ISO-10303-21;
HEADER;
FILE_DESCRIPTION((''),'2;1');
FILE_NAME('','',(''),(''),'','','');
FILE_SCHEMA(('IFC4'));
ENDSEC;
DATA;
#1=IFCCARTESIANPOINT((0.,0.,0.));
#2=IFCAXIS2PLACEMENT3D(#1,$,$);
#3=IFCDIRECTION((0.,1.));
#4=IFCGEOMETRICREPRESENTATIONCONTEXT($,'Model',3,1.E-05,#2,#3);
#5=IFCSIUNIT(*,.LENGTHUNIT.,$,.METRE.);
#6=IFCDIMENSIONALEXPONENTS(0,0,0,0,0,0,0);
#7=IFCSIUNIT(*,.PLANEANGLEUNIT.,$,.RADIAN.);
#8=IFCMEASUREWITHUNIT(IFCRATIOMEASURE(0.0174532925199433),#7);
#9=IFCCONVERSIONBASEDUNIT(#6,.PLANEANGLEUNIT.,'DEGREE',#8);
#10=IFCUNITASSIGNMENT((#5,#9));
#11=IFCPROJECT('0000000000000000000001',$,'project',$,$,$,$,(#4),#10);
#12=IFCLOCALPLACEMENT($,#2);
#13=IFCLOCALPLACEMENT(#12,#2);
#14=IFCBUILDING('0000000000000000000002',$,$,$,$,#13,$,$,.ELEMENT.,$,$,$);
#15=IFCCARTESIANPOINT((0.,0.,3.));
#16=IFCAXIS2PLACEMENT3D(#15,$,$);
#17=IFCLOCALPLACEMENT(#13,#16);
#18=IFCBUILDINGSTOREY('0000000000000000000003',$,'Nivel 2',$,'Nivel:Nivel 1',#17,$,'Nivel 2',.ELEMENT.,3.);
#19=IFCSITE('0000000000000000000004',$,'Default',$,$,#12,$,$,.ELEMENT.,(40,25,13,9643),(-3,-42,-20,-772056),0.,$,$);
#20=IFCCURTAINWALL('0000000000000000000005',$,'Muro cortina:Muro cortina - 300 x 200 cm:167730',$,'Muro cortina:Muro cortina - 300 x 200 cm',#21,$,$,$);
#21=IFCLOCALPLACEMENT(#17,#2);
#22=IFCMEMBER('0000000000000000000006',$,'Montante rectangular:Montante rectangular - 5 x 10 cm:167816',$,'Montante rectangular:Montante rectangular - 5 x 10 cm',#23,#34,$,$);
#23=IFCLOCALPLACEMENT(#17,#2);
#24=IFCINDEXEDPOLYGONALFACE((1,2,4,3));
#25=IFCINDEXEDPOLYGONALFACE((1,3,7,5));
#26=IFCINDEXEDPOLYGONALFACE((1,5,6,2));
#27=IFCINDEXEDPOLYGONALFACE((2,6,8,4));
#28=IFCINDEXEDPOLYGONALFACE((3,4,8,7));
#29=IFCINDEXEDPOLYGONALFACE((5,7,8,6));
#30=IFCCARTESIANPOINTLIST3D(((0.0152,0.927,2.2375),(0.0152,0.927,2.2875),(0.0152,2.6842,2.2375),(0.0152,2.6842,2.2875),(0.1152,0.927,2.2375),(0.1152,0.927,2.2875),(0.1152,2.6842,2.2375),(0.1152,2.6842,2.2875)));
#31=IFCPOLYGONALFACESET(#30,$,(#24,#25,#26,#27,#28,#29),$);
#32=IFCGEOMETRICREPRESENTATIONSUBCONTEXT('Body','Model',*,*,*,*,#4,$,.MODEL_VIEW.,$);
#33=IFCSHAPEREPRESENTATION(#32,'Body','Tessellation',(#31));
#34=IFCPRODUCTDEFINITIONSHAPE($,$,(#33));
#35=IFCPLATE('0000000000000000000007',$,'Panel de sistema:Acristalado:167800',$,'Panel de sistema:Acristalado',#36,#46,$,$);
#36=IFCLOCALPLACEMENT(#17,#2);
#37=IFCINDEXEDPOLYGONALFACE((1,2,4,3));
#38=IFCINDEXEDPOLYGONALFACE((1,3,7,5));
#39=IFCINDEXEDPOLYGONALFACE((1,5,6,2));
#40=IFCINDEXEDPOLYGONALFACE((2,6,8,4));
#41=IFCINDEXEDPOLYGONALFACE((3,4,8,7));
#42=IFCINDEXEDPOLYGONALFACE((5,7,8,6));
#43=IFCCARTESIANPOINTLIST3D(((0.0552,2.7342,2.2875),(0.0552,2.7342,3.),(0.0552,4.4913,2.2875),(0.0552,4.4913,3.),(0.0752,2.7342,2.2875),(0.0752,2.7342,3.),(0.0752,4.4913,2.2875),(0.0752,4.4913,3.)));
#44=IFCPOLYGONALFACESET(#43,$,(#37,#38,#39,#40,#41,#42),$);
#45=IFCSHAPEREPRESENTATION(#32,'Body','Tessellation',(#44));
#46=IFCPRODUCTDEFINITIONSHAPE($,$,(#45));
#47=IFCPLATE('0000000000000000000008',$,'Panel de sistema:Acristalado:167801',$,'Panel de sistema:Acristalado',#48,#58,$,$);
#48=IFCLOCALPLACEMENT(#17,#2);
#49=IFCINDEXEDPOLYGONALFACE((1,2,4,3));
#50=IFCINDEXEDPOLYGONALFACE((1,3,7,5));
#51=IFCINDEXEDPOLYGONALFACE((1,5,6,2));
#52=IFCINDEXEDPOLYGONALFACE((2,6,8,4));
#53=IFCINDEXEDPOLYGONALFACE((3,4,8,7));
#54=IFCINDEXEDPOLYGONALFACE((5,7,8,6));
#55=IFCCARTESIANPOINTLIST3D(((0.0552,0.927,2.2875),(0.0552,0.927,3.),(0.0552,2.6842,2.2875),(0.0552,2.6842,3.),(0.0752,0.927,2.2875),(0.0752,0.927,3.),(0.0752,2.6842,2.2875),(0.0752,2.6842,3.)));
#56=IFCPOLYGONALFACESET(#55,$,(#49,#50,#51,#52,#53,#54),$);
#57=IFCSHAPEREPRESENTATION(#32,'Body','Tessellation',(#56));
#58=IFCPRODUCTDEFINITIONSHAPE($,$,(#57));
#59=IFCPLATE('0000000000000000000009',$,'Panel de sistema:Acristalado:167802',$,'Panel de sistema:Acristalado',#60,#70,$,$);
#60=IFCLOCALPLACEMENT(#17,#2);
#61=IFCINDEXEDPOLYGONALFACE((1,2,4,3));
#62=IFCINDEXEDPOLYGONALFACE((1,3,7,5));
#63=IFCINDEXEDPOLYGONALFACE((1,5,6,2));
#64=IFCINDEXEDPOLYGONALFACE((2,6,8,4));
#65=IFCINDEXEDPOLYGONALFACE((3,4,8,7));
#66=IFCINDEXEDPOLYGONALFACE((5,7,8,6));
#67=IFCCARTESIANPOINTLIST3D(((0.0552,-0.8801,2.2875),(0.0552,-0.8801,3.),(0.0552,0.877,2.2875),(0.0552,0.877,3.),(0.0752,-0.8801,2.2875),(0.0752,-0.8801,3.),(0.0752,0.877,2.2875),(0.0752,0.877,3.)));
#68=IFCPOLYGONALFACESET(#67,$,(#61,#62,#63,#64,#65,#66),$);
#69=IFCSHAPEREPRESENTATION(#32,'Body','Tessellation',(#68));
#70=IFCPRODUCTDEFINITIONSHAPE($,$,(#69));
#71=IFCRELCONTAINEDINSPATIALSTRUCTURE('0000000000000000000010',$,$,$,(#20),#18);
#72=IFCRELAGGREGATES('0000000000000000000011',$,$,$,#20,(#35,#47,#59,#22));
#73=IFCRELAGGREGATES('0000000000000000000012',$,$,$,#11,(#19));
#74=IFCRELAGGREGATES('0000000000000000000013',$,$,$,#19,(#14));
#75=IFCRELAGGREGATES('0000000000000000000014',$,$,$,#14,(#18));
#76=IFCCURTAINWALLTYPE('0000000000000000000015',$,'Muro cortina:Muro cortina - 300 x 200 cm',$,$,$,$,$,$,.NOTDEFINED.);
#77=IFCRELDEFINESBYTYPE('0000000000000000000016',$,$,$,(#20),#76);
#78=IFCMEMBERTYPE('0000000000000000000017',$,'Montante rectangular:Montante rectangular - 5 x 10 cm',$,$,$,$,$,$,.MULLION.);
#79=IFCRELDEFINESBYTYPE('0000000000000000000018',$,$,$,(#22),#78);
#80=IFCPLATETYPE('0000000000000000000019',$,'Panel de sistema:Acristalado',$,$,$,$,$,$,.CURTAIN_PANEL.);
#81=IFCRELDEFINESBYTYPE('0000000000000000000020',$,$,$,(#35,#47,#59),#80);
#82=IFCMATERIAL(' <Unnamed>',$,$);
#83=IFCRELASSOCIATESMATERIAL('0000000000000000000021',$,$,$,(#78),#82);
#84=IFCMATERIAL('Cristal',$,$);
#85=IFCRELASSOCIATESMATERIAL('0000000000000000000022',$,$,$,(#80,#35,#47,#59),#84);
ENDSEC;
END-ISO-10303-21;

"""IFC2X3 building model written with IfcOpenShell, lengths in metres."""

from ifc_helpers import new_model, entity, si_unit, converted_unit, direction, frame, origin, origin_2d_with_axis, place, context, subcontext, project, spatial, rectangle, extrude, source, transform, mapped, material, type_object, type_shapes, element, aggregate, save


model = new_model("IFC2X3")

# Units and contexts
model_context = context("Model", 3, precision=1e-05, world=origin(), true_north=direction((0.0, 1.0)))
body_context = subcontext(model_context, "Body", "Model", "MODEL_VIEW")
ifc_project = project(units=[si_unit("LENGTHUNIT", "METRE"), converted_unit("PLANEANGLEUNIT", "DEGREE", entity("IfcRatioMeasure", 0.0174532925199433), si_unit("PLANEANGLEUNIT", "RADIAN"), dimensions=[0, 0, 0, 0, 0, 0, 0])], contexts=[model_context])

# Site, building, storey
site_placement = place(None, origin())
site = spatial("IfcSite", under=ifc_project, at=site_placement, Name="Default", CompositionType="ELEMENT", RefLatitude=(40, 25, 13, 9643), RefLongitude=(-3, -42, -20, -772056), RefElevation=0.0)
building_placement = place(site_placement, origin())
building = spatial("IfcBuilding", under=site, at=building_placement, CompositionType="ELEMENT")
storey_placement = place(building_placement, frame((0.0, 0.0, 3.0)))
storey = spatial("IfcBuildingStorey", under=building, at=storey_placement, Name="Nivel 2", ObjectType="Nivel:Nivel 1", LongName="Nivel 2", CompositionType="ELEMENT", Elevation=3.0)

# Curtain wall, member, plates
curtain_wall_type = type_object("IfcCurtainWallType", Name="Muro cortina:Muro cortina - 300 x 200 cm", PredefinedType="NOTDEFINED")
curtain_wall_placement = place(storey_placement, frame((0.0, 0.0, -3.0)))
curtain_wall = element("IfcCurtainWall", 1, at=curtain_wall_placement, inside=storey, type_object=curtain_wall_type, Name="Muro cortina:Muro cortina - 300 x 200 cm:167730", ObjectType="Muro cortina:Muro cortina - 300 x 200 cm")
ifc_material_1 = material(Name=" <Unnamed>")
member_type_1 = type_object("IfcMemberType", Name="Montante rectangular:Montante rectangular - 5 x 10 cm", PredefinedType="MULLION", material=ifc_material_1)
shared_shape_1 = source(origin(), body_context, "Body", "SweptSolid", [
    extrude(rectangle(XDim=0.1, YDim=0.05, at=origin_2d_with_axis()), frame((0.0, 0.0, -1.7571), z_axis=(0.0, 0.0, 1.0), x_axis=(0.0, -1.0, 0.0)), (0.0, 0.0, 1.0), 1.7571),
])
type_shapes(member_type_1, [shared_shape_1])
member_1_placement = place(storey_placement, frame((0.0652, 0.927, 2.2625), z_axis=(0.0, -1.0, 0.0), x_axis=(0.0, 0.0, 1.0)))
member_1 = element("IfcMember", 2, at=member_1_placement, type_object=member_type_1, Name="Montante rectangular:Montante rectangular - 5 x 10 cm:167816", ObjectType="Montante rectangular:Montante rectangular - 5 x 10 cm", context=body_context, shape_type="MappedRepresentation", body=[
    mapped(shared_shape_1, transform((0.0, 0.0, 0.0), scale=1.0)),
])
ifc_material_2 = material(Name="Cristal")
plate_type = type_object("IfcPlateType", Name="Panel de sistema:Acristalado", PredefinedType="CURTAIN_PANEL", material=ifc_material_2)
shared_shape_2 = source(origin(), body_context, "Body", "SweptSolid", [
    extrude(rectangle(XDim=0.02, YDim=1.7571, at=origin_2d_with_axis()), frame((0.0, 0.0, 0.0), z_axis=(0.0, 0.0, 1.0), x_axis=(0.0, 1.0, 0.0)), (0.0, 0.0, 1.0), 0.7125),
])
type_shapes(plate_type, [shared_shape_2])
plate_1_placement = place(curtain_wall_placement, frame((0.0652, 3.6127, 5.2875), z_axis=(0.0, 0.0, 1.0), x_axis=(0.0, -1.0, 0.0)))
plate_1 = element("IfcPlate", 3, at=plate_1_placement, type_object=plate_type, material=ifc_material_2, Name="Panel de sistema:Acristalado:167800", ObjectType="Panel de sistema:Acristalado", context=body_context, shape_type="MappedRepresentation", body=[
    mapped(shared_shape_2, transform((0.0, 0.0, 0.0), scale=1.0)),
])
plate_2_placement = place(curtain_wall_placement, frame((0.0652, 1.8056, 5.2875), z_axis=(0.0, 0.0, 1.0), x_axis=(0.0, -1.0, 0.0)))
plate_2 = element("IfcPlate", 4, at=plate_2_placement, type_object=plate_type, material=ifc_material_2, Name="Panel de sistema:Acristalado:167801", ObjectType="Panel de sistema:Acristalado", context=body_context, shape_type="MappedRepresentation", body=[
    mapped(shared_shape_2, transform((0.0, 0.0, 0.0), scale=1.0)),
])
plate_3_placement = place(curtain_wall_placement, frame((0.0652, -0.0015, 5.2875), z_axis=(0.0, 0.0, 1.0), x_axis=(0.0, -1.0, 0.0)))
plate_3 = element("IfcPlate", 5, at=plate_3_placement, type_object=plate_type, material=ifc_material_2, Name="Panel de sistema:Acristalado:167802", ObjectType="Panel de sistema:Acristalado", context=body_context, shape_type="MappedRepresentation", body=[
    mapped(shared_shape_2, transform((0.0, 0.0, 0.0), scale=1.0)),
])
aggregate(curtain_wall, [plate_1, plate_2, plate_3, member_1])

save(model, "model.ifc")
